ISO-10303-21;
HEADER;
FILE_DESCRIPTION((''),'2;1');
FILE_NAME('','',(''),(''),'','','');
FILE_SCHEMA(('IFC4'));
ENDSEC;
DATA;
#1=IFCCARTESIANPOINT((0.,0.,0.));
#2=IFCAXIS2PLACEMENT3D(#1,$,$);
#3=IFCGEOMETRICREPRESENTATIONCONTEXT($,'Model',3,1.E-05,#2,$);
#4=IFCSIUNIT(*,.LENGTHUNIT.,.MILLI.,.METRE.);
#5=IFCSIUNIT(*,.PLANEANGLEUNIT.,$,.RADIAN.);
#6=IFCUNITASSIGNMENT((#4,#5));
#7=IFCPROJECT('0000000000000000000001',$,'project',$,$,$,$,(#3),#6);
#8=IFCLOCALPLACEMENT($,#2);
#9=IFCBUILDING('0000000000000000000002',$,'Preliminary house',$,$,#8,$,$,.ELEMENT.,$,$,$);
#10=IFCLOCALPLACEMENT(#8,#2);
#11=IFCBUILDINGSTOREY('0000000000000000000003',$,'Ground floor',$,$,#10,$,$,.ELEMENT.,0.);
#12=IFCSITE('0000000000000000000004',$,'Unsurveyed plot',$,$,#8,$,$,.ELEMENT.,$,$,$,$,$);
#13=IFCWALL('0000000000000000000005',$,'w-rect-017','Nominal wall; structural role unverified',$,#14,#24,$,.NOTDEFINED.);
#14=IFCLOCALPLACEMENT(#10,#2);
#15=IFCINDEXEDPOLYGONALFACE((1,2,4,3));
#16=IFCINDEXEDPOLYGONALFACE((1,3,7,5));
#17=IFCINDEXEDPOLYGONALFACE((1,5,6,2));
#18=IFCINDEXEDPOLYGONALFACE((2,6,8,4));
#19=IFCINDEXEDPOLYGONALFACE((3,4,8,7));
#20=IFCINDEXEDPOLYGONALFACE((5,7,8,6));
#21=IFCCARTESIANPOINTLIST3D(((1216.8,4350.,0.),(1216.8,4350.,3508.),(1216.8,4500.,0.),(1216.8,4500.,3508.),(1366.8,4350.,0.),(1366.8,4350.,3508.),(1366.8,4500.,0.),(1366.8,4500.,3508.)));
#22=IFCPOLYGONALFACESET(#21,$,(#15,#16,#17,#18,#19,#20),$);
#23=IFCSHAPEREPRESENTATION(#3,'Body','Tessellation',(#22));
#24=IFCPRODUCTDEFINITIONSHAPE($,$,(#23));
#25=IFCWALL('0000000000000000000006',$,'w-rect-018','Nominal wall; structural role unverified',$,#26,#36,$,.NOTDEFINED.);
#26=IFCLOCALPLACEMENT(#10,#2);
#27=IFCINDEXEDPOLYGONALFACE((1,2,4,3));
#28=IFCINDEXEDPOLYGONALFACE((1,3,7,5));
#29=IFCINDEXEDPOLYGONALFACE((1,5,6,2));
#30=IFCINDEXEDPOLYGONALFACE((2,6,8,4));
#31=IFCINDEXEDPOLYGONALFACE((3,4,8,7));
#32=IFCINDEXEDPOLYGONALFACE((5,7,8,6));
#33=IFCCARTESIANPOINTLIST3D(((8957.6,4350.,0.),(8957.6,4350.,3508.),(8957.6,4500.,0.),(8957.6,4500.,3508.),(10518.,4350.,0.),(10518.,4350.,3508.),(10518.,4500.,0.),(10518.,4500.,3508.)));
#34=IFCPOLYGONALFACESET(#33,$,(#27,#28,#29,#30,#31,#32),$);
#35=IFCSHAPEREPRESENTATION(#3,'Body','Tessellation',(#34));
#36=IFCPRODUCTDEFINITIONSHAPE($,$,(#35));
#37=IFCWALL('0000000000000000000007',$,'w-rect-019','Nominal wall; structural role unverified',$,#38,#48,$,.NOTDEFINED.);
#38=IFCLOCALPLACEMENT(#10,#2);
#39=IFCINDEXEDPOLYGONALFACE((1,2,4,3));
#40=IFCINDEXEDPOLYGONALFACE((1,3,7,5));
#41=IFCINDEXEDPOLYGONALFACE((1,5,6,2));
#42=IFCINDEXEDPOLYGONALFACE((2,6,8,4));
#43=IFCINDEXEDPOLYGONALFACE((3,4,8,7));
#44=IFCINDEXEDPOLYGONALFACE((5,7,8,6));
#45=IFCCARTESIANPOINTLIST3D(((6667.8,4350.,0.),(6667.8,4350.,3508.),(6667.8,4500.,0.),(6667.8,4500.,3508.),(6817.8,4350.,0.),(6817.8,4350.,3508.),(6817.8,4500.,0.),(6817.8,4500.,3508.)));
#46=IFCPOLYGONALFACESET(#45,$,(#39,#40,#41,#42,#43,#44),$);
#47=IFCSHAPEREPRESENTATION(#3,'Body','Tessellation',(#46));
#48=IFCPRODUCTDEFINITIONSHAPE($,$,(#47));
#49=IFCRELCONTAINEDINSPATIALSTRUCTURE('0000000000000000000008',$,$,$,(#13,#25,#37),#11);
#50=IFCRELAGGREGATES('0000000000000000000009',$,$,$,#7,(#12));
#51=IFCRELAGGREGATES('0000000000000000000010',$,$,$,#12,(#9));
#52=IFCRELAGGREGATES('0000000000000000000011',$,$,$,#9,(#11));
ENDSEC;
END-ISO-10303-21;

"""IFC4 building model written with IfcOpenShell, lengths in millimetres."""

from ifc_helpers import new_model, si_unit, origin, place, context, project, spatial, polyline, outline, extrude, element, save


model = new_model("IFC4")

# Units and contexts
model_context = context("Model", 3, precision=1e-05, world=origin())
ifc_project = project(units=[si_unit("LENGTHUNIT", "METRE", prefix="MILLI"), si_unit("PLANEANGLEUNIT", "RADIAN")], contexts=[model_context])

# Site, building, storey
placement_1 = place(None, origin())
site = spatial("IfcSite", under=ifc_project, at=placement_1, Name="Unsurveyed plot", CompositionType="ELEMENT")
building = spatial("IfcBuilding", under=site, at=placement_1, Name="Preliminary house", CompositionType="ELEMENT")
placement_2 = place(placement_1, origin())
storey = spatial("IfcBuildingStorey", under=building, at=placement_2, Name="Ground floor", CompositionType="ELEMENT", Elevation=0.0)

# Walls
element("IfcWall", 1, at=placement_2, inside=storey, Name="w-rect-017", Description="Nominal wall; structural role unverified", PredefinedType="NOTDEFINED", context=model_context, shape_type="SweptSolid", body=[
    extrude(outline(polyline([(1216.8, 4350.0), (1366.8, 4350.0), (1366.8, 4500.0), (1216.8, 4500.0), (1216.8, 4350.0)])), origin(), (0.0, 0.0, 1.0), 3508.0),
])
element("IfcWall", 2, at=placement_2, inside=storey, Name="w-rect-018", Description="Nominal wall; structural role unverified", PredefinedType="NOTDEFINED", context=model_context, shape_type="SweptSolid", body=[
    extrude(outline(polyline([(8957.6, 4350.0), (10518.0, 4350.0), (10518.0, 4500.0), (8957.6, 4500.0), (8957.6, 4350.0)])), origin(), (0.0, 0.0, 1.0), 3508.0),
])
element("IfcWall", 3, at=placement_2, inside=storey, Name="w-rect-019", Description="Nominal wall; structural role unverified", PredefinedType="NOTDEFINED", context=model_context, shape_type="SweptSolid", body=[
    extrude(outline(polyline([(6667.8, 4350.0), (6817.8, 4350.0), (6817.8, 4500.0), (6667.8, 4500.0), (6667.8, 4350.0)])), origin(), (0.0, 0.0, 1.0), 3508.0),
])

save(model, "model.ifc")
